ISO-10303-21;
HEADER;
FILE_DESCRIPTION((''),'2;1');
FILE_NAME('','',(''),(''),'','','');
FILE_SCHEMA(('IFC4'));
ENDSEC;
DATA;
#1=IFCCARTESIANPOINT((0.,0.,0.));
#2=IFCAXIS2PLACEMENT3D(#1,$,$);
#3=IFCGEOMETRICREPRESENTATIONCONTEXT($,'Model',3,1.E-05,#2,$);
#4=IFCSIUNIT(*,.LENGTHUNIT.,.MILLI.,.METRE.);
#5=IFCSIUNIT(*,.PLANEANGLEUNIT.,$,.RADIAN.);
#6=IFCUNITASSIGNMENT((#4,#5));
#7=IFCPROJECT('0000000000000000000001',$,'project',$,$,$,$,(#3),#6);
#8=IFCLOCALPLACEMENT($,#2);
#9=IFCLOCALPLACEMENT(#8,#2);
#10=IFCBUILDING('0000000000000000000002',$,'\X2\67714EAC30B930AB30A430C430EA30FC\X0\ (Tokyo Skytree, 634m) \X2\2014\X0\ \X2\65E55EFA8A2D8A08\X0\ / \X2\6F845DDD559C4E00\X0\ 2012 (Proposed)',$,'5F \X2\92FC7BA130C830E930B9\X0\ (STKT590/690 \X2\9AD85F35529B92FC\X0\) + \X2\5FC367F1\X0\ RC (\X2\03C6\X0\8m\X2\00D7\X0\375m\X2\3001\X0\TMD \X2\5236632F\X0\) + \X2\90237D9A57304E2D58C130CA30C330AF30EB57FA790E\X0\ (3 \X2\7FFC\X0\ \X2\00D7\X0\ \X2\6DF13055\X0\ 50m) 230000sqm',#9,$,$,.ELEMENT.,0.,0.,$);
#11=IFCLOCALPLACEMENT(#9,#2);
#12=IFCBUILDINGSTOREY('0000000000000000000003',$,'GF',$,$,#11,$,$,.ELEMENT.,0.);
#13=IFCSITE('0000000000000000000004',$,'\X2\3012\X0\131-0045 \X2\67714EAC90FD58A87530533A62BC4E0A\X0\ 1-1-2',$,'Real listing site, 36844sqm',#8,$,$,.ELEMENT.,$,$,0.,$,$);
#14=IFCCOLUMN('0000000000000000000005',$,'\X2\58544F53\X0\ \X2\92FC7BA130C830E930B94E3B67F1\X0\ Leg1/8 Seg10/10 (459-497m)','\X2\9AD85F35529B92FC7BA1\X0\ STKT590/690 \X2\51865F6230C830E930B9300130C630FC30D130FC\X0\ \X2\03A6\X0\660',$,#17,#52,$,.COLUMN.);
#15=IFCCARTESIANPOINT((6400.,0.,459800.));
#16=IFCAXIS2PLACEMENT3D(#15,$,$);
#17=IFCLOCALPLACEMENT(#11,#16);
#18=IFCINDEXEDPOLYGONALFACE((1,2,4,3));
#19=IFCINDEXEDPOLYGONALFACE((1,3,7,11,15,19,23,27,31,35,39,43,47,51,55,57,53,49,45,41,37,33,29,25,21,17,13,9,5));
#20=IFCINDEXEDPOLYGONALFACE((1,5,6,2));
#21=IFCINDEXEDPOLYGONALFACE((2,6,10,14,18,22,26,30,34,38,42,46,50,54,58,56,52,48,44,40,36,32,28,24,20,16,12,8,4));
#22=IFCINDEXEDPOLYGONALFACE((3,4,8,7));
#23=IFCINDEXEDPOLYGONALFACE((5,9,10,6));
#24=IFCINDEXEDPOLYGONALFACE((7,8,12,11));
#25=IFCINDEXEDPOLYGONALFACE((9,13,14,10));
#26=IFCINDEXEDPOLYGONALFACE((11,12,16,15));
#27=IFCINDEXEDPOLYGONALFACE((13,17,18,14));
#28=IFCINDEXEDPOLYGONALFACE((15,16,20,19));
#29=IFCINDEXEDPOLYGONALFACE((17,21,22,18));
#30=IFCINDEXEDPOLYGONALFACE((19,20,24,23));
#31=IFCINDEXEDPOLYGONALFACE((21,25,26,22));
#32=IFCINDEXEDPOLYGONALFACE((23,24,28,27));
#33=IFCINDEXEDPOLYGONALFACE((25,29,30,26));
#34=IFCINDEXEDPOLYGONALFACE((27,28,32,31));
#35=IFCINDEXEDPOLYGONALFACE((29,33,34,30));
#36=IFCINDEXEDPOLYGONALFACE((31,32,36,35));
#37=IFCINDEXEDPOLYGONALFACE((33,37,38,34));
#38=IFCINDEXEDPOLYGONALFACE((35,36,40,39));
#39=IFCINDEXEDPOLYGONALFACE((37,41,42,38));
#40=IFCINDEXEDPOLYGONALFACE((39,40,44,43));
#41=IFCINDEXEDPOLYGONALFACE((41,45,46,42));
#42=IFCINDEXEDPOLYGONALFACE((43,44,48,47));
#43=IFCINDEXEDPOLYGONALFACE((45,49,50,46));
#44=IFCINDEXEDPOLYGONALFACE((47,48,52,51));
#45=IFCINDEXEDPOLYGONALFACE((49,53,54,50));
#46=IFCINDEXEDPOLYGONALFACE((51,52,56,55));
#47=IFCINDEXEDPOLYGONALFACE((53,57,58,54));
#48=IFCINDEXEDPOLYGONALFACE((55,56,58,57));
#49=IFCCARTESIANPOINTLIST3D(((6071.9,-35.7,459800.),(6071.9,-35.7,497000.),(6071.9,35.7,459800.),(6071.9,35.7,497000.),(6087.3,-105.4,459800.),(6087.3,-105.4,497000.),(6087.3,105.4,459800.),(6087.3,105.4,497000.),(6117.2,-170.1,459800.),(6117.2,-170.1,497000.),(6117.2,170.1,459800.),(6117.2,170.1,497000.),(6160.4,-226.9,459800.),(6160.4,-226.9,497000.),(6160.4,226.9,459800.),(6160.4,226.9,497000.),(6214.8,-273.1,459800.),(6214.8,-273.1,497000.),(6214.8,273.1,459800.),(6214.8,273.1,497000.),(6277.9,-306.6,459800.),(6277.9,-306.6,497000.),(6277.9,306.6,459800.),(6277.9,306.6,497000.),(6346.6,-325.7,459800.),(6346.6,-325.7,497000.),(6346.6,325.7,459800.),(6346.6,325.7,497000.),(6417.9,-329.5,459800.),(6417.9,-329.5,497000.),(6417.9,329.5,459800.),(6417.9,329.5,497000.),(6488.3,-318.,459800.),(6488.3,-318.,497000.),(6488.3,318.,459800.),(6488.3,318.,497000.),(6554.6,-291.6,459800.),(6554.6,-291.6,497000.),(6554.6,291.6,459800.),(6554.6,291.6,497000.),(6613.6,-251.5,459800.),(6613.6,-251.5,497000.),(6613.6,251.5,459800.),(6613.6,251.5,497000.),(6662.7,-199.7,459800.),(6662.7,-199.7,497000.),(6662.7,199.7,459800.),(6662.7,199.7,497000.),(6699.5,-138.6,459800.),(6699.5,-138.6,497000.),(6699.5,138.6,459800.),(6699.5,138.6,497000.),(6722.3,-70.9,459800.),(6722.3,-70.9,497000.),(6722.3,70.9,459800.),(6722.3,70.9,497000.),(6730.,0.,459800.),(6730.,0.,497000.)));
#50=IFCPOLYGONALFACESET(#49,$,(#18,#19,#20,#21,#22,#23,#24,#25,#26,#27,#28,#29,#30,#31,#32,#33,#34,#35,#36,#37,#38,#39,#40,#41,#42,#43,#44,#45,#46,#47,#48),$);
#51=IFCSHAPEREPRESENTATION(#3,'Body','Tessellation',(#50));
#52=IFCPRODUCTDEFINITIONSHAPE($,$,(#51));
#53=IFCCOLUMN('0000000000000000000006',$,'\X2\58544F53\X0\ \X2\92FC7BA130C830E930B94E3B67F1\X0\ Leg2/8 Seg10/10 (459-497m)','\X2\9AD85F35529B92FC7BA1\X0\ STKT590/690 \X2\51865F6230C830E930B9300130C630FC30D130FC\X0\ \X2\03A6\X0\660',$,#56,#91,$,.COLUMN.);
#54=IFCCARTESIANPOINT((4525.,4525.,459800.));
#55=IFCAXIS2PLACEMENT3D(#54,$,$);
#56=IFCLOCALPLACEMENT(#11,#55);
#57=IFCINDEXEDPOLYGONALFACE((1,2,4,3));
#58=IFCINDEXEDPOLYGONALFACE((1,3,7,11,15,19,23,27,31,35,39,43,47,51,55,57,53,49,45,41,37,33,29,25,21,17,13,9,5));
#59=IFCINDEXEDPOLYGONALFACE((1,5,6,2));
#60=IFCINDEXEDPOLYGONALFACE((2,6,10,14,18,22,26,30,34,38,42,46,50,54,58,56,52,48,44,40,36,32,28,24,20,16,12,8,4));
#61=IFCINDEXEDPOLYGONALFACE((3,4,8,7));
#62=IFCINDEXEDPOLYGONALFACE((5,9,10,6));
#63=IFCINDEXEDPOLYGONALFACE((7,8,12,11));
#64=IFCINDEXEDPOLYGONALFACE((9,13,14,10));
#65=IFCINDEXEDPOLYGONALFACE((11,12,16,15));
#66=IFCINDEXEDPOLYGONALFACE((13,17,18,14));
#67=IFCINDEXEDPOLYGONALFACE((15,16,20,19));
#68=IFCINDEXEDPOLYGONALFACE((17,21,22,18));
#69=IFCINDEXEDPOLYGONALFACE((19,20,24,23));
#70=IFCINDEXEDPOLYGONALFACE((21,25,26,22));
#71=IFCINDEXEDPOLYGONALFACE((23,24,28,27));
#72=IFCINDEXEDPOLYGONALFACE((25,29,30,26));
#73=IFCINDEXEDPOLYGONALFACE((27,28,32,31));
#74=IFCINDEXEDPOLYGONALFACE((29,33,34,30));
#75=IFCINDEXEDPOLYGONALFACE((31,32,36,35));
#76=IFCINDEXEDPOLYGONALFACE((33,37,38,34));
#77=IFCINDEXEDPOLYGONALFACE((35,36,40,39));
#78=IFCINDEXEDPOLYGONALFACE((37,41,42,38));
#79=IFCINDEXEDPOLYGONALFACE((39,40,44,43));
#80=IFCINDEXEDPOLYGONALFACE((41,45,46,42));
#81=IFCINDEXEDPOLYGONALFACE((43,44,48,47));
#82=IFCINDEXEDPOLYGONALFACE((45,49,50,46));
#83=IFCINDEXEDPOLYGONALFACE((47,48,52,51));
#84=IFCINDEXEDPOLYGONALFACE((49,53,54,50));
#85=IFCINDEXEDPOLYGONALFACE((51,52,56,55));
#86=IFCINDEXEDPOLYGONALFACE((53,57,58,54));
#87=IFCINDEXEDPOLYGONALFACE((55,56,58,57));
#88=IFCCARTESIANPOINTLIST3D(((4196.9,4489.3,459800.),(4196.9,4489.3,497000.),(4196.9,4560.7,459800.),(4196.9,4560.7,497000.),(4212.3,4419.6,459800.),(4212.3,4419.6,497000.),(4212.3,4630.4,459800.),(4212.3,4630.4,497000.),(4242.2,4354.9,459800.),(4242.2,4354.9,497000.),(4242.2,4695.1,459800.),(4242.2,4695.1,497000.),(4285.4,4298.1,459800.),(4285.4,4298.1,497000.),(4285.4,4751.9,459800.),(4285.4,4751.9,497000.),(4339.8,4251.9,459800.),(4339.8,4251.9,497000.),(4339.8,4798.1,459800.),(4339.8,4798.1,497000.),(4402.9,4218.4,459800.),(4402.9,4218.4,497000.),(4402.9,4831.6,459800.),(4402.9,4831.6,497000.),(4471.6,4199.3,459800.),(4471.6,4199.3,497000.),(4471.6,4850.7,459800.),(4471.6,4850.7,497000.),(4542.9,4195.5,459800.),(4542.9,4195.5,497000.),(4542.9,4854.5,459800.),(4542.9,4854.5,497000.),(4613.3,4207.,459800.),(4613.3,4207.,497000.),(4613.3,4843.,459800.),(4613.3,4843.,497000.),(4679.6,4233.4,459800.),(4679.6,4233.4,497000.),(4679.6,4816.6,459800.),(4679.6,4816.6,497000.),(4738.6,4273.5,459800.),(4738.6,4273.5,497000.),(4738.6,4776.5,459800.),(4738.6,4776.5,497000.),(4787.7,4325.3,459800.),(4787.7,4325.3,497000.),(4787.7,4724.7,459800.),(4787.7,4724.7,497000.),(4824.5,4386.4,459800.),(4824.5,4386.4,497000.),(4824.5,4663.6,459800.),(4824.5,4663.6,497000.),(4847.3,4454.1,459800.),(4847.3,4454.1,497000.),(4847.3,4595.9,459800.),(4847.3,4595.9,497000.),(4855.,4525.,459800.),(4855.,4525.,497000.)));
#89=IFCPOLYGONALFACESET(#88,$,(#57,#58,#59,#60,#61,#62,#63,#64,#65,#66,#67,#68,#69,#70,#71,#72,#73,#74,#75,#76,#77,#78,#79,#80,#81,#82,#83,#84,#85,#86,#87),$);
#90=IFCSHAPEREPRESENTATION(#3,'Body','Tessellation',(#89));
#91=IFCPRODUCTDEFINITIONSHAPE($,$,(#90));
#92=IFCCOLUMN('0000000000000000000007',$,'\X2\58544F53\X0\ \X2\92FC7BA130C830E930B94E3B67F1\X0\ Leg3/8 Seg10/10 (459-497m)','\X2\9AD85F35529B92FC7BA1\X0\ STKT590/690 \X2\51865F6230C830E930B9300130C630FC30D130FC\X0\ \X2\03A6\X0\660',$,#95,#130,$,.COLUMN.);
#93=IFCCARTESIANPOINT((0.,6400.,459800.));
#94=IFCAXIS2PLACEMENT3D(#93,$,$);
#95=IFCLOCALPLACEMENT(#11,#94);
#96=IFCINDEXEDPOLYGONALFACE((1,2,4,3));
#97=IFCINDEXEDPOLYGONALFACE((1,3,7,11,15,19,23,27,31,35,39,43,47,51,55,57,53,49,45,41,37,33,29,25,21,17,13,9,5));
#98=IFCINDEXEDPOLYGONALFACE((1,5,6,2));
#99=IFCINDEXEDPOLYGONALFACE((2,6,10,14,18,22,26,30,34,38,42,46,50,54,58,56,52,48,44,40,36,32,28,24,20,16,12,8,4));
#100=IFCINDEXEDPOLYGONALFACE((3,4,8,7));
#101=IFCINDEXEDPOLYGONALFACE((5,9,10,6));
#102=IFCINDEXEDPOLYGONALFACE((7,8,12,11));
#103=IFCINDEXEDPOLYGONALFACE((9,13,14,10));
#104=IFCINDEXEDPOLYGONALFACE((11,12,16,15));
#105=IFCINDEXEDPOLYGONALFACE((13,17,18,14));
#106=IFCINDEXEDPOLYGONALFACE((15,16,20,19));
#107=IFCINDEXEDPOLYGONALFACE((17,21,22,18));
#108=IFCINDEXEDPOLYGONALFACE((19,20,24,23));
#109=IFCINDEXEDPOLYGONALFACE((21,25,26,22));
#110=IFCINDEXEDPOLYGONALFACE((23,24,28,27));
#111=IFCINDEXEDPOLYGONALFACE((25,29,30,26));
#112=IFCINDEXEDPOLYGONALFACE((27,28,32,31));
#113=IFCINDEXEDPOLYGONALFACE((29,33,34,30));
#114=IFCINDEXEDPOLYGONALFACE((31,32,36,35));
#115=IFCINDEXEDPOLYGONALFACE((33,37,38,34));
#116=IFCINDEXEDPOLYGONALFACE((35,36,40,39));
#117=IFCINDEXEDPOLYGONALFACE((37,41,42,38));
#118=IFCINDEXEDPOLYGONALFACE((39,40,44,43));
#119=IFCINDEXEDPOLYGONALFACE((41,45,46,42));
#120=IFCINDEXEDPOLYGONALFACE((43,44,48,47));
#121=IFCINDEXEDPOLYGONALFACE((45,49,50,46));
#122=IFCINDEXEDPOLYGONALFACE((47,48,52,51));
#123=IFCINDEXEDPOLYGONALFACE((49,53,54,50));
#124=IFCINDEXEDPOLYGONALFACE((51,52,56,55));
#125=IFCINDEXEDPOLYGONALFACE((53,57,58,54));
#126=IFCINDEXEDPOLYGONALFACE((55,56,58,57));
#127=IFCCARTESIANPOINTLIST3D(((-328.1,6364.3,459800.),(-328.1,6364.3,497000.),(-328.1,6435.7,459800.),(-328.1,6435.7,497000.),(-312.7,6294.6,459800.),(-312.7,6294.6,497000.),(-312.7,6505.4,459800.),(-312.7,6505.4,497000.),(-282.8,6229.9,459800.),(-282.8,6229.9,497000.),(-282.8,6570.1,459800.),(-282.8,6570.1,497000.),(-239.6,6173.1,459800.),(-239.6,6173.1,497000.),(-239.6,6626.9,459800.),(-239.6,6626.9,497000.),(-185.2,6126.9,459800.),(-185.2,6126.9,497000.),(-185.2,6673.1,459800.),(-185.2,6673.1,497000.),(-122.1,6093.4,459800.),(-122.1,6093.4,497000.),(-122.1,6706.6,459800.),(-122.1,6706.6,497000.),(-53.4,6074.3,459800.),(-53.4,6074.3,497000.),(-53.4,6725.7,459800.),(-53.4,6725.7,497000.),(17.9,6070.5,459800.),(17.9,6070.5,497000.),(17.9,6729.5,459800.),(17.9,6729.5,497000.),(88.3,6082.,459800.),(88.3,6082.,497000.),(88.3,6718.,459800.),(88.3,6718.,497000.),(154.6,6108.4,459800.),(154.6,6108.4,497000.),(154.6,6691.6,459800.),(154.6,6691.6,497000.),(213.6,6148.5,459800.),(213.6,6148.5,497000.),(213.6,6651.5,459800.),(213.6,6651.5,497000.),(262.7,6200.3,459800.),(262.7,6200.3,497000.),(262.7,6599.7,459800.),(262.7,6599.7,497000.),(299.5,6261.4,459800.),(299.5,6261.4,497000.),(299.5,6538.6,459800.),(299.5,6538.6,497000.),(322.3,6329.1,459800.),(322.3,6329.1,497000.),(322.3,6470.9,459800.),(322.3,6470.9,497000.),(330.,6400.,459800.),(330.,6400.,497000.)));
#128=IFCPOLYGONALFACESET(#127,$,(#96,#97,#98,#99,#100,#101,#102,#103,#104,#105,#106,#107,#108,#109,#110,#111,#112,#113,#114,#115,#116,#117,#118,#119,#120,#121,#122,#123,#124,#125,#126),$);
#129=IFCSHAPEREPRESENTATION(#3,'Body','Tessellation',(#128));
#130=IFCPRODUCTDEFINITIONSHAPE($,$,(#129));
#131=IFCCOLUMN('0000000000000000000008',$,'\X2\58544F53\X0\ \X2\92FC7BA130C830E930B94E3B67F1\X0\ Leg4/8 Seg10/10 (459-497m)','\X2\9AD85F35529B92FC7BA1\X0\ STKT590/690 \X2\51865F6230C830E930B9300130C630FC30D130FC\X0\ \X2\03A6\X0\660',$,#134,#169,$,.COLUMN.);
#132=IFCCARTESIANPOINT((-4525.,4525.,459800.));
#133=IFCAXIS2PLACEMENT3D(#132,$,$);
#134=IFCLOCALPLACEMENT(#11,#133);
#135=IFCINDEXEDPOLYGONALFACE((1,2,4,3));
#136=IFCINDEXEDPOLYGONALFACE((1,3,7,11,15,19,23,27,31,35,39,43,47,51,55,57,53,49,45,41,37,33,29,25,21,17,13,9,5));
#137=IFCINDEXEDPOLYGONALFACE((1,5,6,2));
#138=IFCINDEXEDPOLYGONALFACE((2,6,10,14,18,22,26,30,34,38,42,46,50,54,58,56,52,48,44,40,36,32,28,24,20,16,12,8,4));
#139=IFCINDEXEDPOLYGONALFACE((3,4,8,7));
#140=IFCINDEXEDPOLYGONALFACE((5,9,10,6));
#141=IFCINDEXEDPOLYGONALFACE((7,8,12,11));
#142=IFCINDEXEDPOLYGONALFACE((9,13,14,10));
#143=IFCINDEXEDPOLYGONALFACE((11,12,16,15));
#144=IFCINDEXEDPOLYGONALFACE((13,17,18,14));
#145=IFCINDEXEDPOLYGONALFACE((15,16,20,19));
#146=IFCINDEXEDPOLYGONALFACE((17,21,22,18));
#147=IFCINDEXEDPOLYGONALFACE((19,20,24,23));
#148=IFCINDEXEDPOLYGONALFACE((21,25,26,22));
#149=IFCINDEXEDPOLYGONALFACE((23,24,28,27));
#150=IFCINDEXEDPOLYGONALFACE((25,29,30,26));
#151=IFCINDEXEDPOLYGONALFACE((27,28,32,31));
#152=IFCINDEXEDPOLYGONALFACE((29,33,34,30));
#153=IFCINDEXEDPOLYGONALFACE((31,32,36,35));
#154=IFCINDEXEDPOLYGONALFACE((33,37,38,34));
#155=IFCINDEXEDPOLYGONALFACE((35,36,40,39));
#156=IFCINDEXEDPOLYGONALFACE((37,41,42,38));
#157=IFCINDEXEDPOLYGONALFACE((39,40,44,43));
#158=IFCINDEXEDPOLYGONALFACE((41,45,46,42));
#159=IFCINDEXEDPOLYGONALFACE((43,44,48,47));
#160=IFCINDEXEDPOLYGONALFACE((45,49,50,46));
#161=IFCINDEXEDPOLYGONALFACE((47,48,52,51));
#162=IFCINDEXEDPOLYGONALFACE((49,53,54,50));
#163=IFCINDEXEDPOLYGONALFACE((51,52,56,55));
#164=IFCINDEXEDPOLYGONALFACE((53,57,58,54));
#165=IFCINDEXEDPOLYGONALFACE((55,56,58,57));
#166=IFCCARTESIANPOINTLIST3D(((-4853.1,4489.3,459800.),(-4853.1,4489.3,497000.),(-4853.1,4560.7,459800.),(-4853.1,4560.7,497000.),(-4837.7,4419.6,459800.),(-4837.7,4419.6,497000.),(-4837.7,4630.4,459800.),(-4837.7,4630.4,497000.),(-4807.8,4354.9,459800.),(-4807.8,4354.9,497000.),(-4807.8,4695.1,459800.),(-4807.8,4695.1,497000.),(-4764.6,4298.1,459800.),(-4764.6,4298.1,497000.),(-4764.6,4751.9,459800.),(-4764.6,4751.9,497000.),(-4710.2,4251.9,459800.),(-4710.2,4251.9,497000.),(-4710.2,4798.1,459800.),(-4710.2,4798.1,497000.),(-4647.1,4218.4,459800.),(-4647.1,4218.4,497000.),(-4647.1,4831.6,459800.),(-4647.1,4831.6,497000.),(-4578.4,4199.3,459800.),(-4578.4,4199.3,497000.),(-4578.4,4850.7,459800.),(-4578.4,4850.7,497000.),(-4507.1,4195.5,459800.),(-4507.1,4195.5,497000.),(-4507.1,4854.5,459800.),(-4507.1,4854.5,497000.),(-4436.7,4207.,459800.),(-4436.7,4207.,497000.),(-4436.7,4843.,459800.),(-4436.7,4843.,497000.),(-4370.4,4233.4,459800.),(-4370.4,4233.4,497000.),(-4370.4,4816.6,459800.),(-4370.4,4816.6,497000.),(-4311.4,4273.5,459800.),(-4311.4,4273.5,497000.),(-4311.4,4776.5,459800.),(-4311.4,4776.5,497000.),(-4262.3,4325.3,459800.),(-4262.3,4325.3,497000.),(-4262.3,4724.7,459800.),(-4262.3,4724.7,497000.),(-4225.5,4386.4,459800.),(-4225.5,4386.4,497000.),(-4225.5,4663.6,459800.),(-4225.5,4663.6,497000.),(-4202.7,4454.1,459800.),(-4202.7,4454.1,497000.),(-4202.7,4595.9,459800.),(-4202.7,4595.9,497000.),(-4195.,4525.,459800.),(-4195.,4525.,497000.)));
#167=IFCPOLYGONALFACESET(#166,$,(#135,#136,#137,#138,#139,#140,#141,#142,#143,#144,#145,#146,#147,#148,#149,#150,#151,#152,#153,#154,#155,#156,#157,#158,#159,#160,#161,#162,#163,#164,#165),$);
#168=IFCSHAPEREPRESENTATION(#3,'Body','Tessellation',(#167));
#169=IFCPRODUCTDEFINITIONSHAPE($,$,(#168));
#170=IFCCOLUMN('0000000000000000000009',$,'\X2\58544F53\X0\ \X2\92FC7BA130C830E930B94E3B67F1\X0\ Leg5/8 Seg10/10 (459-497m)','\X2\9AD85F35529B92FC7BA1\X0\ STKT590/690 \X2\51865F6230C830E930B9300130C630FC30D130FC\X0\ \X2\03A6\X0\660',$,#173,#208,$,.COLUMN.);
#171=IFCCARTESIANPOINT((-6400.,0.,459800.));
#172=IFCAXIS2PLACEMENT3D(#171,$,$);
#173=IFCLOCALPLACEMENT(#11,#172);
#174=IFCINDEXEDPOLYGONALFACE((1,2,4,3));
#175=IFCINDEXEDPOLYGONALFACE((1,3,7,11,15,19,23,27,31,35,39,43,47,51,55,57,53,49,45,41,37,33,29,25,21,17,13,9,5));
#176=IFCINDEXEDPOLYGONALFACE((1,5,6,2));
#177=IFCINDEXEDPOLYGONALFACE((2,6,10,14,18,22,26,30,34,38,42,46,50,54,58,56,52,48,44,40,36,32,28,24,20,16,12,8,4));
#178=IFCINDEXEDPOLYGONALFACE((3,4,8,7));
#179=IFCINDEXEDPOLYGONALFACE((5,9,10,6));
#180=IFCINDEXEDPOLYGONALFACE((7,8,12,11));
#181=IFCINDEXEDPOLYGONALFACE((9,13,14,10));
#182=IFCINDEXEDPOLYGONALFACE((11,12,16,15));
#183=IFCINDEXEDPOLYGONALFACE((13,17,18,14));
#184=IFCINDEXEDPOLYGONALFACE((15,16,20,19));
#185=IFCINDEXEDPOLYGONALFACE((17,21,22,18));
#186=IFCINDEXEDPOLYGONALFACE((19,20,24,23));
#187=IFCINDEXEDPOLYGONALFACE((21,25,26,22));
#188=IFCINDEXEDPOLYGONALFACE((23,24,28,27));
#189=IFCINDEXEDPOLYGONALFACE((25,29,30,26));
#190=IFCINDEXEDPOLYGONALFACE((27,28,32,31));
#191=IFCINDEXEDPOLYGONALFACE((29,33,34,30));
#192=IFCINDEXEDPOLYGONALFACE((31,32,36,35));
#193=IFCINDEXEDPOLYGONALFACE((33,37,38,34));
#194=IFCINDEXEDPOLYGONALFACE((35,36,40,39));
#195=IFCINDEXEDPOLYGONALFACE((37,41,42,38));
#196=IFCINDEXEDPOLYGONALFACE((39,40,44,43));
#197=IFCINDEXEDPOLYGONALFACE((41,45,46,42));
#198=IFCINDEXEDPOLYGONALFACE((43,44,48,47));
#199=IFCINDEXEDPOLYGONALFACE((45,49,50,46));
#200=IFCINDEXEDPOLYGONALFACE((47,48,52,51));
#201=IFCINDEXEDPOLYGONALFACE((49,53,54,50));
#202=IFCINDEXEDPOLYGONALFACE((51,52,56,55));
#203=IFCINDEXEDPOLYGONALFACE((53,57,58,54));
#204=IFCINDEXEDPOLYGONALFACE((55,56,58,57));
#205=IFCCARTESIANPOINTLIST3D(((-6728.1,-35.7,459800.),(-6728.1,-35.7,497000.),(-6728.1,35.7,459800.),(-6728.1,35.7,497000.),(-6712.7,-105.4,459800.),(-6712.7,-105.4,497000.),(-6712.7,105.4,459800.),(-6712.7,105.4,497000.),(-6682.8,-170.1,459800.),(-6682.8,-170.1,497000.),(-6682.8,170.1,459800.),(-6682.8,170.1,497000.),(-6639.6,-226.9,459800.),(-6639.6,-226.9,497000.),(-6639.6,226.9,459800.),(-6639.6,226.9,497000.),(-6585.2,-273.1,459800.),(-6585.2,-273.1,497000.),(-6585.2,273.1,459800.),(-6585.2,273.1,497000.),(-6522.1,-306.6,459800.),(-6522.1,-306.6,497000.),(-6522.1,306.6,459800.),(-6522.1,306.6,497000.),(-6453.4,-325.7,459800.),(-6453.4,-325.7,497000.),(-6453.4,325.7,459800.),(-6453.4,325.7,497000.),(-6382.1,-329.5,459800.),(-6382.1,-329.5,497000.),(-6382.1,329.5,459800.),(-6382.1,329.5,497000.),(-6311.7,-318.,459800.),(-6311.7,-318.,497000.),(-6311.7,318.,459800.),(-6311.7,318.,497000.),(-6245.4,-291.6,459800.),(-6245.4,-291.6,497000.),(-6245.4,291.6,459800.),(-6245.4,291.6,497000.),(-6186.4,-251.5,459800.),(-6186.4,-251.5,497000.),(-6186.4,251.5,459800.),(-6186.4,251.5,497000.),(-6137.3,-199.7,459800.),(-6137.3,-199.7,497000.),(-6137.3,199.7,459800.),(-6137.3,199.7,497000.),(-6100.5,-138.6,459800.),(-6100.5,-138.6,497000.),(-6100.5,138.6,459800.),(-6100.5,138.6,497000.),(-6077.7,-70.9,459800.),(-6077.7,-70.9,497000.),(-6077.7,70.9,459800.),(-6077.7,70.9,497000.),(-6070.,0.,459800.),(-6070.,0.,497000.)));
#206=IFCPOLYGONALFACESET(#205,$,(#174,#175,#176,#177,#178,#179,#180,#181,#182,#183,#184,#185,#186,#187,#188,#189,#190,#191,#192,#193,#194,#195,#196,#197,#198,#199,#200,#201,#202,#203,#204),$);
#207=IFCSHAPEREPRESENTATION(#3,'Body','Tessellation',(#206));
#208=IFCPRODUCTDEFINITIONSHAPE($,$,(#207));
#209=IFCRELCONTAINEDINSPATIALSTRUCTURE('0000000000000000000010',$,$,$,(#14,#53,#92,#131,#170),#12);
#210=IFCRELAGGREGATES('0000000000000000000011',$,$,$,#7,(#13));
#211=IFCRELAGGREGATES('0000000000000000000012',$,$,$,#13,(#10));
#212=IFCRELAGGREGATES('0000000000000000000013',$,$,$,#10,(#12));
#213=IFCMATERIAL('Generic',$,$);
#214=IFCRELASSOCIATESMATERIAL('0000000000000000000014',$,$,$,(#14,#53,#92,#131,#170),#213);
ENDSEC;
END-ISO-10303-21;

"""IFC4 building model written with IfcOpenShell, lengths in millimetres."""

from ifc_helpers import new_model, si_unit, frame, origin, origin_2d, place, context, project, spatial, circle, extrude, material, element, save


model = new_model("IFC4")

# Units and contexts
model_context = context("Model", 3, precision=1e-05, world=origin())
ifc_project = project(units=[si_unit("LENGTHUNIT", "METRE", prefix="MILLI"), si_unit("PLANEANGLEUNIT", "RADIAN")], contexts=[model_context])

# Site, building, storey
site_placement = place(None, origin())
site = spatial("IfcSite", under=ifc_project, at=site_placement, Name="〒131-0045 東京都墨田区押上 1-1-2", ObjectType="Real listing site, 36844sqm", CompositionType="ELEMENT", RefElevation=0.0)
building_placement = place(site_placement, origin())
building = spatial("IfcBuilding", under=site, at=building_placement, Name="東京スカイツリー (Tokyo Skytree, 634m) — 日建設計 / 澄川喜一 2012 (Proposed)", ObjectType="5F 鋼管トラス (STKT590/690 高張力鋼) + 心柱 RC (φ8m×375m、TMD 制振) + 連続地中壁ナックル基礎 (3 翼 × 深さ 50m) 230000sqm", CompositionType="ELEMENT", ElevationOfRefHeight=0.0, ElevationOfTerrain=0.0)
storey_placement = place(building_placement, origin())
storey = spatial("IfcBuildingStorey", under=building, at=storey_placement, Name="GF", CompositionType="ELEMENT", Elevation=0.0)

# Columns
ifc_material = material(Name="Generic")
column_1_placement = place(storey_placement, frame((6400.0, 0.0, 459800.0)))
element("IfcColumn", 1, at=column_1_placement, inside=storey, material=ifc_material, Name="塔体 鋼管トラス主柱 Leg1/8 Seg10/10 (459-497m)", Description="高張力鋼管 STKT590/690 円形トラス、テーパー Φ660", PredefinedType="COLUMN", context=model_context, shape_type="SweptSolid", body=[
    extrude(circle(Radius=330.0, at=origin_2d()), frame((6400.0, 0.0, 459800.0)), (0.0, 0.0, 1.0), 37200.0),
])
column_2_placement = place(storey_placement, frame((4525.0, 4525.0, 459800.0)))
element("IfcColumn", 2, at=column_2_placement, inside=storey, material=ifc_material, Name="塔体 鋼管トラス主柱 Leg2/8 Seg10/10 (459-497m)", Description="高張力鋼管 STKT590/690 円形トラス、テーパー Φ660", PredefinedType="COLUMN", context=model_context, shape_type="SweptSolid", body=[
    extrude(circle(Radius=330.0, at=origin_2d()), frame((4525.0, 4525.0, 459800.0)), (0.0, 0.0, 1.0), 37200.0),
])
column_3_placement = place(storey_placement, frame((0.0, 6400.0, 459800.0)))
element("IfcColumn", 3, at=column_3_placement, inside=storey, material=ifc_material, Name="塔体 鋼管トラス主柱 Leg3/8 Seg10/10 (459-497m)", Description="高張力鋼管 STKT590/690 円形トラス、テーパー Φ660", PredefinedType="COLUMN", context=model_context, shape_type="SweptSolid", body=[
    extrude(circle(Radius=330.0, at=origin_2d()), frame((0.0, 6400.0, 459800.0)), (0.0, 0.0, 1.0), 37200.0),
])
column_4_placement = place(storey_placement, frame((-4525.0, 4525.0, 459800.0)))
element("IfcColumn", 4, at=column_4_placement, inside=storey, material=ifc_material, Name="塔体 鋼管トラス主柱 Leg4/8 Seg10/10 (459-497m)", Description="高張力鋼管 STKT590/690 円形トラス、テーパー Φ660", PredefinedType="COLUMN", context=model_context, shape_type="SweptSolid", body=[
    extrude(circle(Radius=330.0, at=origin_2d()), frame((-4525.0, 4525.0, 459800.0)), (0.0, 0.0, 1.0), 37200.0),
])
column_5_placement = place(storey_placement, frame((-6400.0, 0.0, 459800.0)))
element("IfcColumn", 5, at=column_5_placement, inside=storey, material=ifc_material, Name="塔体 鋼管トラス主柱 Leg5/8 Seg10/10 (459-497m)", Description="高張力鋼管 STKT590/690 円形トラス、テーパー Φ660", PredefinedType="COLUMN", context=model_context, shape_type="SweptSolid", body=[
    extrude(circle(Radius=330.0, at=origin_2d()), frame((-6400.0, 0.0, 459800.0)), (0.0, 0.0, 1.0), 37200.0),
])

save(model, "model.ifc")
